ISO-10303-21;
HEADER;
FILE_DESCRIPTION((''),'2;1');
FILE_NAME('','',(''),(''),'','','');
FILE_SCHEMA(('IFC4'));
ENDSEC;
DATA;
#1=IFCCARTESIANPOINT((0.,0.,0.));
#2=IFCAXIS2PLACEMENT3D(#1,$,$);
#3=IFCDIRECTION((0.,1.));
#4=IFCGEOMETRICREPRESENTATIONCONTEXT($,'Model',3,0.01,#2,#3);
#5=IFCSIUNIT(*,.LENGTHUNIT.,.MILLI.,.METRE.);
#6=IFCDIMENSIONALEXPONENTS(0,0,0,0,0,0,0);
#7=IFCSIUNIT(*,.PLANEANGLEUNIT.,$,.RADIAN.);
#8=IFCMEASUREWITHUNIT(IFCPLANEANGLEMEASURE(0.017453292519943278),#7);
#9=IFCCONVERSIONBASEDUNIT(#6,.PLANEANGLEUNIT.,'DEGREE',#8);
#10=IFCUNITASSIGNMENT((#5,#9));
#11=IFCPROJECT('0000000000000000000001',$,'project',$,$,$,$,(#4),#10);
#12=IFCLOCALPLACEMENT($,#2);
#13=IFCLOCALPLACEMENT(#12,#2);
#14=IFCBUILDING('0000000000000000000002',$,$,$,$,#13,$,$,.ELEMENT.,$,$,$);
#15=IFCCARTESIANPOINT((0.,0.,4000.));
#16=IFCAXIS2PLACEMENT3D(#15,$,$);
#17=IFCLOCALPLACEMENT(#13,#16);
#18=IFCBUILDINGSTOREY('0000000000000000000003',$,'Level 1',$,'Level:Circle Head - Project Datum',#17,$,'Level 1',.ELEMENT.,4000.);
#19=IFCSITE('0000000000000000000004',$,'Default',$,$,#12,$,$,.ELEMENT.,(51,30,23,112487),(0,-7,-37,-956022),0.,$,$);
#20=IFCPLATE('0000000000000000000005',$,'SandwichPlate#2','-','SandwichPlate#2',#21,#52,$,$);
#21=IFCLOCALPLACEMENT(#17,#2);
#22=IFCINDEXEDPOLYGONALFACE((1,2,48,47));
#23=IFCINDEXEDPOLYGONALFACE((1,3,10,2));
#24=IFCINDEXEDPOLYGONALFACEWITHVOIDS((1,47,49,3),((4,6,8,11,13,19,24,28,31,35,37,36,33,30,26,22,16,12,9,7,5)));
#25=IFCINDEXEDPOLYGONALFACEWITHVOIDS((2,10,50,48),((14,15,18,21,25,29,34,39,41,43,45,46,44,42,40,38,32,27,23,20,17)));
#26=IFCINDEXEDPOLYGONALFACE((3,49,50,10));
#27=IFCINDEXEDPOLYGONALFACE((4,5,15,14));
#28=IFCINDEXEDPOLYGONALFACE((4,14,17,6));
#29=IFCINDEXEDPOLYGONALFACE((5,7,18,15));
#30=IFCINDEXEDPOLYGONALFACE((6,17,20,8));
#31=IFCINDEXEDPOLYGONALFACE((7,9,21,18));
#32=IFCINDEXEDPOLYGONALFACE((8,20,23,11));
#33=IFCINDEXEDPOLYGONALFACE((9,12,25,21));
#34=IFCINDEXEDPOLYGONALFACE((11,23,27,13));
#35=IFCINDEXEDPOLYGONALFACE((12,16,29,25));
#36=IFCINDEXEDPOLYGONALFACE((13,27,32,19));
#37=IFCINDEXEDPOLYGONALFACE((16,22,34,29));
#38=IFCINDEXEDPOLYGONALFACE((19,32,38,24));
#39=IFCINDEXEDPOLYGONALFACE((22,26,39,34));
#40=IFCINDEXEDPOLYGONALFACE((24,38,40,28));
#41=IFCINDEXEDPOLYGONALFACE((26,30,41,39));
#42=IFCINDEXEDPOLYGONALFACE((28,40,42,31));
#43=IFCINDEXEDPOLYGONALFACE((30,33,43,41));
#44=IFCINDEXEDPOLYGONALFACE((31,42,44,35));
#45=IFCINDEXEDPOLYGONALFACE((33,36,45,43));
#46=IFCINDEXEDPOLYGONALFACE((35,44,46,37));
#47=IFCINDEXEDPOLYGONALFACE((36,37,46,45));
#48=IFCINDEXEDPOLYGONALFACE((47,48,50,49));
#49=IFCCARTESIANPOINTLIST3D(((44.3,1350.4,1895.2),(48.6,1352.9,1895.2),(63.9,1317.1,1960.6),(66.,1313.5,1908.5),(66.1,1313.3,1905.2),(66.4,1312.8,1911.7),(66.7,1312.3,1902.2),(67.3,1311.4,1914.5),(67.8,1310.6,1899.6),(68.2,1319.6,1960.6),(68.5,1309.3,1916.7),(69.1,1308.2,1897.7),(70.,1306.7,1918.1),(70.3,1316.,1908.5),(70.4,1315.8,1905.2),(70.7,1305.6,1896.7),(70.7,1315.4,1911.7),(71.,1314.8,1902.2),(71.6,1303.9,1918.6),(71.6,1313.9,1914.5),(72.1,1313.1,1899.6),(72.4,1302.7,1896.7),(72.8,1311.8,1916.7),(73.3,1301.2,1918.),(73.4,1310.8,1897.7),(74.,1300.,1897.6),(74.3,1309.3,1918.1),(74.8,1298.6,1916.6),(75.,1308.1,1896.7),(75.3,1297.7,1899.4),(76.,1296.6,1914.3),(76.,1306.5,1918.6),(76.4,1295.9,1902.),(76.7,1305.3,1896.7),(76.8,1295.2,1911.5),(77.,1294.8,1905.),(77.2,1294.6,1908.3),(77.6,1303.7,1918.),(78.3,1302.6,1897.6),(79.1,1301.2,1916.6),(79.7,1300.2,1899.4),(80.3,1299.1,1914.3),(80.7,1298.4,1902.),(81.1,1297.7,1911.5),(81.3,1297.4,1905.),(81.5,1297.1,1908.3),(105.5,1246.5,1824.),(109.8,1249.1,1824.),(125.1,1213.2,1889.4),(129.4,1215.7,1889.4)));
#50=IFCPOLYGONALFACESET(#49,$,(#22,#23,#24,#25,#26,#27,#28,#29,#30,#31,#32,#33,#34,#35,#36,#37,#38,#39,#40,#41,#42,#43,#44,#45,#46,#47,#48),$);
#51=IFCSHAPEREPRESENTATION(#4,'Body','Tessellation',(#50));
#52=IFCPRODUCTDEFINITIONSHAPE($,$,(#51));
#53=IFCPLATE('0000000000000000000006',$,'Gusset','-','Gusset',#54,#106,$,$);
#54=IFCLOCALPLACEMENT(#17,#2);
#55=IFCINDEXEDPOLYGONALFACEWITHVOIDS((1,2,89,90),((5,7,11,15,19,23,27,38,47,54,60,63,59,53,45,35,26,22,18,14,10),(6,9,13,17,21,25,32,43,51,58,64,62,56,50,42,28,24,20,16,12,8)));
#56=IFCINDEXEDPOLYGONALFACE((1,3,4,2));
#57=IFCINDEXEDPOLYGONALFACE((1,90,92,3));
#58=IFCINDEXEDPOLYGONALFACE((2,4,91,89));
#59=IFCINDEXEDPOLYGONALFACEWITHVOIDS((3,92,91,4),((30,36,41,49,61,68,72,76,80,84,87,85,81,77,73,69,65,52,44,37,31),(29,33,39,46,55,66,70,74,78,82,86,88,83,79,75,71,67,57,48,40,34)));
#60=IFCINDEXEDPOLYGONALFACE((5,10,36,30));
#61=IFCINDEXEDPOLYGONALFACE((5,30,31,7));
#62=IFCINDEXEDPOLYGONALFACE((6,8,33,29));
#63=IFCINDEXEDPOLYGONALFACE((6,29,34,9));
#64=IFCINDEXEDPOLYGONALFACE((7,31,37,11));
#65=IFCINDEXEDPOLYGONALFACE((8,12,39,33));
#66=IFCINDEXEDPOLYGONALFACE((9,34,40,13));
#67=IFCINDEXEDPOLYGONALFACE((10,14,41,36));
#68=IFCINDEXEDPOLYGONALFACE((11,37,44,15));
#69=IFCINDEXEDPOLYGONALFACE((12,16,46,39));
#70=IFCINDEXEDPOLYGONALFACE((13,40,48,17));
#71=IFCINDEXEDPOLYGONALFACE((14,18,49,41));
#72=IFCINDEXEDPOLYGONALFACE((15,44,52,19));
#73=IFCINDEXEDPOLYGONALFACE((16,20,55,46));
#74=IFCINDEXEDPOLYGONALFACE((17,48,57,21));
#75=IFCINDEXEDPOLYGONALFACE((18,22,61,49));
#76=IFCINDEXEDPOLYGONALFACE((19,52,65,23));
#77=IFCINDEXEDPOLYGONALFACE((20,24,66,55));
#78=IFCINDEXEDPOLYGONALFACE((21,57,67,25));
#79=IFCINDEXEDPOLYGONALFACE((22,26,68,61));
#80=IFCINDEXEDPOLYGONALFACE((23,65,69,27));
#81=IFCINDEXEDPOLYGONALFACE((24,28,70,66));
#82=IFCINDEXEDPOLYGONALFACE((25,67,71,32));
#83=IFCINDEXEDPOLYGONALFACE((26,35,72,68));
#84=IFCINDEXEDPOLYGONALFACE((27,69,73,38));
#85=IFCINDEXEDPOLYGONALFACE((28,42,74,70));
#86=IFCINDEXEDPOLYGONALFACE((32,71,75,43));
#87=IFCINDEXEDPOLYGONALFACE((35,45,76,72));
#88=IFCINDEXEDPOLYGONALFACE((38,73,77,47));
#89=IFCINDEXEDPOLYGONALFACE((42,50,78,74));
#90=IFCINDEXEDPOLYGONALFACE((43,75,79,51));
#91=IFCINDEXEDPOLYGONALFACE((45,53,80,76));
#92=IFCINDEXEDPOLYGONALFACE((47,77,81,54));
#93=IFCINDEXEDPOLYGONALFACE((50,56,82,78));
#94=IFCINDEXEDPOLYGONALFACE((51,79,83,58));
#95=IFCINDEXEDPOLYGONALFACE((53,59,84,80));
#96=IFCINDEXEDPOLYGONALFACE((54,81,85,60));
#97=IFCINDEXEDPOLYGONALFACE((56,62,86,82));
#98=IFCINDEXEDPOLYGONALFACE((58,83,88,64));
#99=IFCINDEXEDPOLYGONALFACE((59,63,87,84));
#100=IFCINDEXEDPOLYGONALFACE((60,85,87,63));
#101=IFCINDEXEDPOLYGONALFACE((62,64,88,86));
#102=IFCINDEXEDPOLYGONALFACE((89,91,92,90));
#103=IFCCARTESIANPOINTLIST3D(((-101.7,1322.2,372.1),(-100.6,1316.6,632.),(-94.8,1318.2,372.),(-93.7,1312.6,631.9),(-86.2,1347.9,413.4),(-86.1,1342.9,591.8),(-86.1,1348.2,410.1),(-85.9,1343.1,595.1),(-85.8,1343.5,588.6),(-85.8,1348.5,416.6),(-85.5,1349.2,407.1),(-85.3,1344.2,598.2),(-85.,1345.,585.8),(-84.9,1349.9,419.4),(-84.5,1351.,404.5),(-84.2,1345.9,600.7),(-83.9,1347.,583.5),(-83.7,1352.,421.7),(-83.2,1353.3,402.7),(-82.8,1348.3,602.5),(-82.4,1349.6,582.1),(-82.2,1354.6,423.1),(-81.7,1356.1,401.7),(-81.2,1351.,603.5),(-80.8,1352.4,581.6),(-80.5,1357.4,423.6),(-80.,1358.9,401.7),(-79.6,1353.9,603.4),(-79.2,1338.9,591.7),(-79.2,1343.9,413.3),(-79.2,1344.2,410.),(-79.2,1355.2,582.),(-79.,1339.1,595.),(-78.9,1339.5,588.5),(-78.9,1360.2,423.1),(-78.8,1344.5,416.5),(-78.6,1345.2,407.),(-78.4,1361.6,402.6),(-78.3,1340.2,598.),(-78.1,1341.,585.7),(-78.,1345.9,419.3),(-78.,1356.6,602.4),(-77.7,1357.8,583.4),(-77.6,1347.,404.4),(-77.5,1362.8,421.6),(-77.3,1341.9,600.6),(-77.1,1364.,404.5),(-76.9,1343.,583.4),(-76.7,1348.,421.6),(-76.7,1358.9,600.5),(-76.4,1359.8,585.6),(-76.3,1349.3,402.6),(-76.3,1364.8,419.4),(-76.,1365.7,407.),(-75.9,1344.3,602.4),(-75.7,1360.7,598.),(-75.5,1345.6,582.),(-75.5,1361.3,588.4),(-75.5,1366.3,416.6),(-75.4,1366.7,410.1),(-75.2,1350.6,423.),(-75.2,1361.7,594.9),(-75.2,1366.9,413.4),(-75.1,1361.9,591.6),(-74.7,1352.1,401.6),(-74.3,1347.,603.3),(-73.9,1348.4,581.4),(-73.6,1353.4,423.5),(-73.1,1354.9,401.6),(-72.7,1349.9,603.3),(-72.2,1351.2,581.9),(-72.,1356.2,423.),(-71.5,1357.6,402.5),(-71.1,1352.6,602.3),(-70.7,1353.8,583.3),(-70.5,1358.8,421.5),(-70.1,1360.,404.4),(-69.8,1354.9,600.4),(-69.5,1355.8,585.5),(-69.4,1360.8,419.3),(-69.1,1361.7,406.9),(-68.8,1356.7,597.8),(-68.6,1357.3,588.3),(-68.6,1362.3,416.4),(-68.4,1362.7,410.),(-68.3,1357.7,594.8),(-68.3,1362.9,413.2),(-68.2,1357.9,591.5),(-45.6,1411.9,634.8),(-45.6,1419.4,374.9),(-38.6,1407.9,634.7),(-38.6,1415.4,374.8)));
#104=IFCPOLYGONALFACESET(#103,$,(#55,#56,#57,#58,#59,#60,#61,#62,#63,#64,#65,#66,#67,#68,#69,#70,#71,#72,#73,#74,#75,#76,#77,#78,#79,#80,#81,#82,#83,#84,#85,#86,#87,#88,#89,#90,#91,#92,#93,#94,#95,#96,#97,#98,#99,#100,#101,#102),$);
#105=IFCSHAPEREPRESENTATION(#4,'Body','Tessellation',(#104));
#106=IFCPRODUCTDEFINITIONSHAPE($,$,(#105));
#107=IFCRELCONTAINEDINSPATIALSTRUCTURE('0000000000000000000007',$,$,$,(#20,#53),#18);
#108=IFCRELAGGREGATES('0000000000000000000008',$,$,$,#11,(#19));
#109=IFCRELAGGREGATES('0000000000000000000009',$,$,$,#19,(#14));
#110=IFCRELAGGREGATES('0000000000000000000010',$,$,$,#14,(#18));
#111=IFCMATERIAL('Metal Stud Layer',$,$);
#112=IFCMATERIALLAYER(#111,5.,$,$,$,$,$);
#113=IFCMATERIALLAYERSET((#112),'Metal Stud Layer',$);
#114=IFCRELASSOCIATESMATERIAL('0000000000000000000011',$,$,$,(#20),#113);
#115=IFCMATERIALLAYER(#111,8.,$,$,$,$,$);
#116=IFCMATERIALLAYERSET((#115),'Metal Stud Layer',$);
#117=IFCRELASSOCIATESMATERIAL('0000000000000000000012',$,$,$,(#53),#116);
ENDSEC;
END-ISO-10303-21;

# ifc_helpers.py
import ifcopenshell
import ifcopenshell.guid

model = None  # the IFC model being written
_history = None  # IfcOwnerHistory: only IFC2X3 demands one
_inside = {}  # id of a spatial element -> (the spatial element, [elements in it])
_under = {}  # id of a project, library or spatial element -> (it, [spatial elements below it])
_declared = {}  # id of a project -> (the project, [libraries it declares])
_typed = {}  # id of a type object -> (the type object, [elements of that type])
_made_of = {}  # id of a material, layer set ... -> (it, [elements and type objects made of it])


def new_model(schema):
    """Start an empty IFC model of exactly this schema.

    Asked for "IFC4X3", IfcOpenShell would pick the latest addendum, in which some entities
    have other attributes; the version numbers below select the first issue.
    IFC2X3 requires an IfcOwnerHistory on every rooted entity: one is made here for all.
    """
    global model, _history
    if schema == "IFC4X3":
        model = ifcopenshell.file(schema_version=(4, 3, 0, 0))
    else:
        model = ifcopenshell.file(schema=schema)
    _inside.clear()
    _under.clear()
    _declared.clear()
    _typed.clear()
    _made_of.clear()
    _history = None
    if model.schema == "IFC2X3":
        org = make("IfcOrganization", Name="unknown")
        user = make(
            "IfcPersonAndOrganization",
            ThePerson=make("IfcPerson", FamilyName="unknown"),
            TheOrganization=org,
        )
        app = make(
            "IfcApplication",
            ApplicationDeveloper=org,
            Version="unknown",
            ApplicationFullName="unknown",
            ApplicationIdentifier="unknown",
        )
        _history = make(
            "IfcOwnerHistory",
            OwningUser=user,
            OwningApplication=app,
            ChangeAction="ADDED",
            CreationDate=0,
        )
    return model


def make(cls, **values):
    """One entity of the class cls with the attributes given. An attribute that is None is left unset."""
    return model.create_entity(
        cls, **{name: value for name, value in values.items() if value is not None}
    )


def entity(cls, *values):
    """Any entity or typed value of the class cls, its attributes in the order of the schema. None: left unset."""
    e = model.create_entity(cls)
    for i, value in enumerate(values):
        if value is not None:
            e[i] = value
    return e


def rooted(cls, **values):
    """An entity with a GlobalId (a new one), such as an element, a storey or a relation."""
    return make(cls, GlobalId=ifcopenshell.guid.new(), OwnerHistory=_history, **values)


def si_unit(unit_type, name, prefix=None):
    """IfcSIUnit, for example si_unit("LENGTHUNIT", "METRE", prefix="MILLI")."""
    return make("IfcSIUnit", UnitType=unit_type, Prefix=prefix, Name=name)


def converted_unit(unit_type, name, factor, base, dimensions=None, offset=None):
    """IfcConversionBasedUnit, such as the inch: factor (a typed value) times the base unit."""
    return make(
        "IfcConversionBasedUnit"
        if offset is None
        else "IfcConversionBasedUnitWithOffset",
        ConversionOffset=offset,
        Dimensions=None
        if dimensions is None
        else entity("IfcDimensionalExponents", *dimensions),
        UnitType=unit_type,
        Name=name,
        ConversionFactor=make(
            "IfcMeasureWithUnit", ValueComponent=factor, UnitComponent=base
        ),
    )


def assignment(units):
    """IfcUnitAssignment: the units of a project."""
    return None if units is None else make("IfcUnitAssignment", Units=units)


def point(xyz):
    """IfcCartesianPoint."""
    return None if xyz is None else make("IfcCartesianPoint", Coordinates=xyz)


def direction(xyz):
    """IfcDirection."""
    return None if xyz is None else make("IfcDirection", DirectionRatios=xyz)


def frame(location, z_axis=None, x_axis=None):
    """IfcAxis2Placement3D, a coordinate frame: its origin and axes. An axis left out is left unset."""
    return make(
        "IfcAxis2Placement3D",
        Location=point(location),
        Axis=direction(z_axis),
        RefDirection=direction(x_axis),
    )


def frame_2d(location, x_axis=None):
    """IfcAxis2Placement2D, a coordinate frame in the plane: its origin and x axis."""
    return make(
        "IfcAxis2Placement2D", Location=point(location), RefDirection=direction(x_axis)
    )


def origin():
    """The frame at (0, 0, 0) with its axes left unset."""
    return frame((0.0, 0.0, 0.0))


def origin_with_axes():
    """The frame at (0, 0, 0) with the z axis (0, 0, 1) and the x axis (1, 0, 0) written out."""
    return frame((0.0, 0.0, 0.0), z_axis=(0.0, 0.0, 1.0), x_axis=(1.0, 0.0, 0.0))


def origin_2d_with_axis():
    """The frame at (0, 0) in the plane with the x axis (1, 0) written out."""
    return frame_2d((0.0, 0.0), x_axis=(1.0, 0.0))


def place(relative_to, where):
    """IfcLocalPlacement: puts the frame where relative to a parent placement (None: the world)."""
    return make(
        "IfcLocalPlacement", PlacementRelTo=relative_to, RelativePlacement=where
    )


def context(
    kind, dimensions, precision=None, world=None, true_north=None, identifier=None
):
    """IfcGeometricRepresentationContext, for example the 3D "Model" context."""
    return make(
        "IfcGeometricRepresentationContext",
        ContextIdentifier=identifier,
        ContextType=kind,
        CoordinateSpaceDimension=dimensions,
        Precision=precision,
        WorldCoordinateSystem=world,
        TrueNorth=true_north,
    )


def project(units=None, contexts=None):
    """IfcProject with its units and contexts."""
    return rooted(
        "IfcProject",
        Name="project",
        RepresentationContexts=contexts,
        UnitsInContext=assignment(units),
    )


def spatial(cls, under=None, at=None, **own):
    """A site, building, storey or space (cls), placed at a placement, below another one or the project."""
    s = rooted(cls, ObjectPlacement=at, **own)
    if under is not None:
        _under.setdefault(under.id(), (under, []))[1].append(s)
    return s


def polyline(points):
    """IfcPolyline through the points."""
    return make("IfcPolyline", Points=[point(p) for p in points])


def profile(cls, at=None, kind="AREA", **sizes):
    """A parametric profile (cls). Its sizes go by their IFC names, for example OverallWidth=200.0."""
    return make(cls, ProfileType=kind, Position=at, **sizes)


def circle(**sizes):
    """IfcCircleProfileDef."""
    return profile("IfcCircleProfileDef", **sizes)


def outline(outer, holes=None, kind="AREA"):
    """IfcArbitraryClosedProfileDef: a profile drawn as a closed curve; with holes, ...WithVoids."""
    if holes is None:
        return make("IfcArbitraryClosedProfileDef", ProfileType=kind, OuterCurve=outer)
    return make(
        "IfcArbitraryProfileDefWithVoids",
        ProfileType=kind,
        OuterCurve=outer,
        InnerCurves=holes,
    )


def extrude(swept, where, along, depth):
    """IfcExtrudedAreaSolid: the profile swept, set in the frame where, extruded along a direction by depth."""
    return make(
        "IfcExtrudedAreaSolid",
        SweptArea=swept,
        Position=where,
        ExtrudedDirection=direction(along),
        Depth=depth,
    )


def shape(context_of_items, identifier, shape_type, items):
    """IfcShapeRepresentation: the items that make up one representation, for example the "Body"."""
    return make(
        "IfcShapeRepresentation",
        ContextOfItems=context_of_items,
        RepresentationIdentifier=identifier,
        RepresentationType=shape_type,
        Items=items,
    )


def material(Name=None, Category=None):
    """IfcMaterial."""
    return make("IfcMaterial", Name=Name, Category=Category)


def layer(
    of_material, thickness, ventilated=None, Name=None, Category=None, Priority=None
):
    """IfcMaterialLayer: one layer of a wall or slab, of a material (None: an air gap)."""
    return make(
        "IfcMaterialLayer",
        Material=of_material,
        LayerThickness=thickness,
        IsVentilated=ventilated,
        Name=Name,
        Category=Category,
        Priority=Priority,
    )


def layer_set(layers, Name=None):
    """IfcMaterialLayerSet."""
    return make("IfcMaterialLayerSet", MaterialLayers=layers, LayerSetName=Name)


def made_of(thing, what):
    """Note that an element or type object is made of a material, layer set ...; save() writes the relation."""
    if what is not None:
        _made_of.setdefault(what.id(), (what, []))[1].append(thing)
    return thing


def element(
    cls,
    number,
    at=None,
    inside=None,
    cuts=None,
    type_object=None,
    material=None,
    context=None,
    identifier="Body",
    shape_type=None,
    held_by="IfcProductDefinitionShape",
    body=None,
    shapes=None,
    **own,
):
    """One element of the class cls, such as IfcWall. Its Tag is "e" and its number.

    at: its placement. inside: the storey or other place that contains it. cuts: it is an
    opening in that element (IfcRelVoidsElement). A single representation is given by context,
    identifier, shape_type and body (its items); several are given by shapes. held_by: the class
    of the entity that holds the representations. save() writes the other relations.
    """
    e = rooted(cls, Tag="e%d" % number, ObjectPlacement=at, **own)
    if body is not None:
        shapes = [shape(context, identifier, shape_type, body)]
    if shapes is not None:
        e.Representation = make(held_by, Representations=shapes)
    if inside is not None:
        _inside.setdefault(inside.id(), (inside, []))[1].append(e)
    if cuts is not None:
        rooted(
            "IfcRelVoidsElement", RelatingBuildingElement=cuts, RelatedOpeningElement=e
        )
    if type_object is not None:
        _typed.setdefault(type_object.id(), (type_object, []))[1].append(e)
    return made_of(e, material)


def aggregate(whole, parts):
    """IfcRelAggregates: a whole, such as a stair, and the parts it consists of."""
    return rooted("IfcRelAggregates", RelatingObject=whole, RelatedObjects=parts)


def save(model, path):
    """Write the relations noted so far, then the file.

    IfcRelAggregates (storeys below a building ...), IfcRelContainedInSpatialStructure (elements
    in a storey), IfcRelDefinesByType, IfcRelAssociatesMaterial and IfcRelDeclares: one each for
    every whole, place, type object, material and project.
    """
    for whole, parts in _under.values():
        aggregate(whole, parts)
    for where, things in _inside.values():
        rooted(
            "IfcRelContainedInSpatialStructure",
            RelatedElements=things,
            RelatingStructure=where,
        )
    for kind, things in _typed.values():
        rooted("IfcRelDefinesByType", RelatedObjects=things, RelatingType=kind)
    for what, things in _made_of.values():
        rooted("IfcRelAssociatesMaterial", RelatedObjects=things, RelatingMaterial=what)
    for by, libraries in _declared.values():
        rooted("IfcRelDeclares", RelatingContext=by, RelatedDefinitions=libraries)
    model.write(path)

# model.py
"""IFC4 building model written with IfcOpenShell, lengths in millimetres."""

from ifc_helpers import new_model, entity, si_unit, converted_unit, direction, frame, origin, origin_with_axes, origin_2d_with_axis, place, context, project, spatial, polyline, circle, outline, extrude, material, layer, layer_set, element, save


model = new_model("IFC4")

# Units and contexts
model_context = context("Model", 3, precision=0.01, world=origin(), true_north=direction((0.0, 1.0)))
ifc_project = project(units=[si_unit("LENGTHUNIT", "METRE", prefix="MILLI"), converted_unit("PLANEANGLEUNIT", "DEGREE", entity("IfcPlaneAngleMeasure", 0.017453292519943278), si_unit("PLANEANGLEUNIT", "RADIAN"), dimensions=[0, 0, 0, 0, 0, 0, 0])], contexts=[model_context])

# Site, building, storey
site_placement = place(None, origin())
site = spatial("IfcSite", under=ifc_project, at=site_placement, Name="Default", CompositionType="ELEMENT", RefLatitude=(51, 30, 23, 112487), RefLongitude=(0, -7, -37, -956022), RefElevation=0.0)
building_placement = place(site_placement, origin())
building = spatial("IfcBuilding", under=site, at=building_placement, CompositionType="ELEMENT")
storey_placement = place(building_placement, frame((0.0, 0.0, 4000.0)))
storey = spatial("IfcBuildingStorey", under=building, at=storey_placement, Name="Level 1", ObjectType="Level:Circle Head - Project Datum", LongName="Level 1", CompositionType="ELEMENT", Elevation=4000.0)

# Shared definitions
ifc_material_1 = material(Name="Metal Stud Layer")
ifc_layer_1 = layer(ifc_material_1, 5.0)
ifc_layer_set_1 = layer_set([ifc_layer_1], Name="Metal Stud Layer")
ifc_layer_2 = layer(ifc_material_1, 8.0)
ifc_layer_set_2 = layer_set([ifc_layer_2], Name="Metal Stud Layer")

# Plate, opening
plate_1_placement = place(storey_placement, frame((68.2, 1319.6, 1960.6), z_axis=(-0.861728, -0.507371, 0.0), x_axis=(-0.258184, 0.438505, -0.860845)))
plate_1 = element("IfcPlate", 1, at=plate_1_placement, inside=storey, material=ifc_layer_set_1, Name="SandwichPlate#2", Description="-", ObjectType="SandwichPlate#2", context=model_context, shape_type="SweptSolid", body=[
    extrude(outline(polyline([(0.0, 0.0), (76.0, 0.0), (76.0, 140.0), (0.0, 140.0), (0.0, 0.0)])), origin_with_axes(), (0.0, 0.0, 1.0), 5.0),
])
opening_1_placement = place(plate_1_placement, frame((38.0, 40.0, -0.5), z_axis=(0.0, 0.0, 1.0), x_axis=(0.0, 1.0, 0.0)))
element("IfcOpeningElement", 2, at=opening_1_placement, cuts=plate_1, ObjectType="Opening", context=model_context, shape_type="SweptSolid", body=[
    extrude(circle(Radius=11.0, at=origin_2d_with_axis()), origin(), (0.0, 0.0, 1.0), 6.0),
])

# Plate, openings
plate_2_placement = place(storey_placement, frame((-39.8, 1405.9, 634.8), z_axis=(-0.865935, 0.499948, 0.014432), x_axis=(0.0, 0.028855, -0.999584)))
plate_2 = element("IfcPlate", 3, at=plate_2_placement, inside=storey, material=ifc_layer_set_2, Name="Gusset", Description="-", ObjectType="Gusset", context=model_context, shape_type="SweptSolid", body=[
    extrude(outline(polyline([(0.2, -2.3), (260.2, -2.3), (260.2, 110.0), (0.2, 107.8), (0.2, -2.3)])), origin_with_axes(), (0.0, 0.0, 1.0), 8.0),
])
opening_2_placement = place(plate_2_placement, frame((40.7, 67.8, 8.5), z_axis=(0.0, 0.0, -1.0), x_axis=(-0.530279, 0.847823, 0.0)))
element("IfcOpeningElement", 4, at=opening_2_placement, cuts=plate_2, ObjectType="Opening", context=model_context, shape_type="SweptSolid", body=[
    extrude(circle(Radius=11.0, at=origin_2d_with_axis()), origin(), (0.0, 0.0, 1.0), 9.0),
])
opening_3_placement = place(plate_2_placement, frame((220.8, 68.0, 8.5), z_axis=(0.0, 0.0, -1.0), x_axis=(0.47613, 0.879375, 0.0)))
element("IfcOpeningElement", 5, at=opening_3_placement, cuts=plate_2, ObjectType="Opening", context=model_context, shape_type="SweptSolid", body=[
    extrude(circle(Radius=11.0, at=origin_2d_with_axis()), origin(), (0.0, 0.0, 1.0), 9.0),
])

save(model, "model.ifc")
